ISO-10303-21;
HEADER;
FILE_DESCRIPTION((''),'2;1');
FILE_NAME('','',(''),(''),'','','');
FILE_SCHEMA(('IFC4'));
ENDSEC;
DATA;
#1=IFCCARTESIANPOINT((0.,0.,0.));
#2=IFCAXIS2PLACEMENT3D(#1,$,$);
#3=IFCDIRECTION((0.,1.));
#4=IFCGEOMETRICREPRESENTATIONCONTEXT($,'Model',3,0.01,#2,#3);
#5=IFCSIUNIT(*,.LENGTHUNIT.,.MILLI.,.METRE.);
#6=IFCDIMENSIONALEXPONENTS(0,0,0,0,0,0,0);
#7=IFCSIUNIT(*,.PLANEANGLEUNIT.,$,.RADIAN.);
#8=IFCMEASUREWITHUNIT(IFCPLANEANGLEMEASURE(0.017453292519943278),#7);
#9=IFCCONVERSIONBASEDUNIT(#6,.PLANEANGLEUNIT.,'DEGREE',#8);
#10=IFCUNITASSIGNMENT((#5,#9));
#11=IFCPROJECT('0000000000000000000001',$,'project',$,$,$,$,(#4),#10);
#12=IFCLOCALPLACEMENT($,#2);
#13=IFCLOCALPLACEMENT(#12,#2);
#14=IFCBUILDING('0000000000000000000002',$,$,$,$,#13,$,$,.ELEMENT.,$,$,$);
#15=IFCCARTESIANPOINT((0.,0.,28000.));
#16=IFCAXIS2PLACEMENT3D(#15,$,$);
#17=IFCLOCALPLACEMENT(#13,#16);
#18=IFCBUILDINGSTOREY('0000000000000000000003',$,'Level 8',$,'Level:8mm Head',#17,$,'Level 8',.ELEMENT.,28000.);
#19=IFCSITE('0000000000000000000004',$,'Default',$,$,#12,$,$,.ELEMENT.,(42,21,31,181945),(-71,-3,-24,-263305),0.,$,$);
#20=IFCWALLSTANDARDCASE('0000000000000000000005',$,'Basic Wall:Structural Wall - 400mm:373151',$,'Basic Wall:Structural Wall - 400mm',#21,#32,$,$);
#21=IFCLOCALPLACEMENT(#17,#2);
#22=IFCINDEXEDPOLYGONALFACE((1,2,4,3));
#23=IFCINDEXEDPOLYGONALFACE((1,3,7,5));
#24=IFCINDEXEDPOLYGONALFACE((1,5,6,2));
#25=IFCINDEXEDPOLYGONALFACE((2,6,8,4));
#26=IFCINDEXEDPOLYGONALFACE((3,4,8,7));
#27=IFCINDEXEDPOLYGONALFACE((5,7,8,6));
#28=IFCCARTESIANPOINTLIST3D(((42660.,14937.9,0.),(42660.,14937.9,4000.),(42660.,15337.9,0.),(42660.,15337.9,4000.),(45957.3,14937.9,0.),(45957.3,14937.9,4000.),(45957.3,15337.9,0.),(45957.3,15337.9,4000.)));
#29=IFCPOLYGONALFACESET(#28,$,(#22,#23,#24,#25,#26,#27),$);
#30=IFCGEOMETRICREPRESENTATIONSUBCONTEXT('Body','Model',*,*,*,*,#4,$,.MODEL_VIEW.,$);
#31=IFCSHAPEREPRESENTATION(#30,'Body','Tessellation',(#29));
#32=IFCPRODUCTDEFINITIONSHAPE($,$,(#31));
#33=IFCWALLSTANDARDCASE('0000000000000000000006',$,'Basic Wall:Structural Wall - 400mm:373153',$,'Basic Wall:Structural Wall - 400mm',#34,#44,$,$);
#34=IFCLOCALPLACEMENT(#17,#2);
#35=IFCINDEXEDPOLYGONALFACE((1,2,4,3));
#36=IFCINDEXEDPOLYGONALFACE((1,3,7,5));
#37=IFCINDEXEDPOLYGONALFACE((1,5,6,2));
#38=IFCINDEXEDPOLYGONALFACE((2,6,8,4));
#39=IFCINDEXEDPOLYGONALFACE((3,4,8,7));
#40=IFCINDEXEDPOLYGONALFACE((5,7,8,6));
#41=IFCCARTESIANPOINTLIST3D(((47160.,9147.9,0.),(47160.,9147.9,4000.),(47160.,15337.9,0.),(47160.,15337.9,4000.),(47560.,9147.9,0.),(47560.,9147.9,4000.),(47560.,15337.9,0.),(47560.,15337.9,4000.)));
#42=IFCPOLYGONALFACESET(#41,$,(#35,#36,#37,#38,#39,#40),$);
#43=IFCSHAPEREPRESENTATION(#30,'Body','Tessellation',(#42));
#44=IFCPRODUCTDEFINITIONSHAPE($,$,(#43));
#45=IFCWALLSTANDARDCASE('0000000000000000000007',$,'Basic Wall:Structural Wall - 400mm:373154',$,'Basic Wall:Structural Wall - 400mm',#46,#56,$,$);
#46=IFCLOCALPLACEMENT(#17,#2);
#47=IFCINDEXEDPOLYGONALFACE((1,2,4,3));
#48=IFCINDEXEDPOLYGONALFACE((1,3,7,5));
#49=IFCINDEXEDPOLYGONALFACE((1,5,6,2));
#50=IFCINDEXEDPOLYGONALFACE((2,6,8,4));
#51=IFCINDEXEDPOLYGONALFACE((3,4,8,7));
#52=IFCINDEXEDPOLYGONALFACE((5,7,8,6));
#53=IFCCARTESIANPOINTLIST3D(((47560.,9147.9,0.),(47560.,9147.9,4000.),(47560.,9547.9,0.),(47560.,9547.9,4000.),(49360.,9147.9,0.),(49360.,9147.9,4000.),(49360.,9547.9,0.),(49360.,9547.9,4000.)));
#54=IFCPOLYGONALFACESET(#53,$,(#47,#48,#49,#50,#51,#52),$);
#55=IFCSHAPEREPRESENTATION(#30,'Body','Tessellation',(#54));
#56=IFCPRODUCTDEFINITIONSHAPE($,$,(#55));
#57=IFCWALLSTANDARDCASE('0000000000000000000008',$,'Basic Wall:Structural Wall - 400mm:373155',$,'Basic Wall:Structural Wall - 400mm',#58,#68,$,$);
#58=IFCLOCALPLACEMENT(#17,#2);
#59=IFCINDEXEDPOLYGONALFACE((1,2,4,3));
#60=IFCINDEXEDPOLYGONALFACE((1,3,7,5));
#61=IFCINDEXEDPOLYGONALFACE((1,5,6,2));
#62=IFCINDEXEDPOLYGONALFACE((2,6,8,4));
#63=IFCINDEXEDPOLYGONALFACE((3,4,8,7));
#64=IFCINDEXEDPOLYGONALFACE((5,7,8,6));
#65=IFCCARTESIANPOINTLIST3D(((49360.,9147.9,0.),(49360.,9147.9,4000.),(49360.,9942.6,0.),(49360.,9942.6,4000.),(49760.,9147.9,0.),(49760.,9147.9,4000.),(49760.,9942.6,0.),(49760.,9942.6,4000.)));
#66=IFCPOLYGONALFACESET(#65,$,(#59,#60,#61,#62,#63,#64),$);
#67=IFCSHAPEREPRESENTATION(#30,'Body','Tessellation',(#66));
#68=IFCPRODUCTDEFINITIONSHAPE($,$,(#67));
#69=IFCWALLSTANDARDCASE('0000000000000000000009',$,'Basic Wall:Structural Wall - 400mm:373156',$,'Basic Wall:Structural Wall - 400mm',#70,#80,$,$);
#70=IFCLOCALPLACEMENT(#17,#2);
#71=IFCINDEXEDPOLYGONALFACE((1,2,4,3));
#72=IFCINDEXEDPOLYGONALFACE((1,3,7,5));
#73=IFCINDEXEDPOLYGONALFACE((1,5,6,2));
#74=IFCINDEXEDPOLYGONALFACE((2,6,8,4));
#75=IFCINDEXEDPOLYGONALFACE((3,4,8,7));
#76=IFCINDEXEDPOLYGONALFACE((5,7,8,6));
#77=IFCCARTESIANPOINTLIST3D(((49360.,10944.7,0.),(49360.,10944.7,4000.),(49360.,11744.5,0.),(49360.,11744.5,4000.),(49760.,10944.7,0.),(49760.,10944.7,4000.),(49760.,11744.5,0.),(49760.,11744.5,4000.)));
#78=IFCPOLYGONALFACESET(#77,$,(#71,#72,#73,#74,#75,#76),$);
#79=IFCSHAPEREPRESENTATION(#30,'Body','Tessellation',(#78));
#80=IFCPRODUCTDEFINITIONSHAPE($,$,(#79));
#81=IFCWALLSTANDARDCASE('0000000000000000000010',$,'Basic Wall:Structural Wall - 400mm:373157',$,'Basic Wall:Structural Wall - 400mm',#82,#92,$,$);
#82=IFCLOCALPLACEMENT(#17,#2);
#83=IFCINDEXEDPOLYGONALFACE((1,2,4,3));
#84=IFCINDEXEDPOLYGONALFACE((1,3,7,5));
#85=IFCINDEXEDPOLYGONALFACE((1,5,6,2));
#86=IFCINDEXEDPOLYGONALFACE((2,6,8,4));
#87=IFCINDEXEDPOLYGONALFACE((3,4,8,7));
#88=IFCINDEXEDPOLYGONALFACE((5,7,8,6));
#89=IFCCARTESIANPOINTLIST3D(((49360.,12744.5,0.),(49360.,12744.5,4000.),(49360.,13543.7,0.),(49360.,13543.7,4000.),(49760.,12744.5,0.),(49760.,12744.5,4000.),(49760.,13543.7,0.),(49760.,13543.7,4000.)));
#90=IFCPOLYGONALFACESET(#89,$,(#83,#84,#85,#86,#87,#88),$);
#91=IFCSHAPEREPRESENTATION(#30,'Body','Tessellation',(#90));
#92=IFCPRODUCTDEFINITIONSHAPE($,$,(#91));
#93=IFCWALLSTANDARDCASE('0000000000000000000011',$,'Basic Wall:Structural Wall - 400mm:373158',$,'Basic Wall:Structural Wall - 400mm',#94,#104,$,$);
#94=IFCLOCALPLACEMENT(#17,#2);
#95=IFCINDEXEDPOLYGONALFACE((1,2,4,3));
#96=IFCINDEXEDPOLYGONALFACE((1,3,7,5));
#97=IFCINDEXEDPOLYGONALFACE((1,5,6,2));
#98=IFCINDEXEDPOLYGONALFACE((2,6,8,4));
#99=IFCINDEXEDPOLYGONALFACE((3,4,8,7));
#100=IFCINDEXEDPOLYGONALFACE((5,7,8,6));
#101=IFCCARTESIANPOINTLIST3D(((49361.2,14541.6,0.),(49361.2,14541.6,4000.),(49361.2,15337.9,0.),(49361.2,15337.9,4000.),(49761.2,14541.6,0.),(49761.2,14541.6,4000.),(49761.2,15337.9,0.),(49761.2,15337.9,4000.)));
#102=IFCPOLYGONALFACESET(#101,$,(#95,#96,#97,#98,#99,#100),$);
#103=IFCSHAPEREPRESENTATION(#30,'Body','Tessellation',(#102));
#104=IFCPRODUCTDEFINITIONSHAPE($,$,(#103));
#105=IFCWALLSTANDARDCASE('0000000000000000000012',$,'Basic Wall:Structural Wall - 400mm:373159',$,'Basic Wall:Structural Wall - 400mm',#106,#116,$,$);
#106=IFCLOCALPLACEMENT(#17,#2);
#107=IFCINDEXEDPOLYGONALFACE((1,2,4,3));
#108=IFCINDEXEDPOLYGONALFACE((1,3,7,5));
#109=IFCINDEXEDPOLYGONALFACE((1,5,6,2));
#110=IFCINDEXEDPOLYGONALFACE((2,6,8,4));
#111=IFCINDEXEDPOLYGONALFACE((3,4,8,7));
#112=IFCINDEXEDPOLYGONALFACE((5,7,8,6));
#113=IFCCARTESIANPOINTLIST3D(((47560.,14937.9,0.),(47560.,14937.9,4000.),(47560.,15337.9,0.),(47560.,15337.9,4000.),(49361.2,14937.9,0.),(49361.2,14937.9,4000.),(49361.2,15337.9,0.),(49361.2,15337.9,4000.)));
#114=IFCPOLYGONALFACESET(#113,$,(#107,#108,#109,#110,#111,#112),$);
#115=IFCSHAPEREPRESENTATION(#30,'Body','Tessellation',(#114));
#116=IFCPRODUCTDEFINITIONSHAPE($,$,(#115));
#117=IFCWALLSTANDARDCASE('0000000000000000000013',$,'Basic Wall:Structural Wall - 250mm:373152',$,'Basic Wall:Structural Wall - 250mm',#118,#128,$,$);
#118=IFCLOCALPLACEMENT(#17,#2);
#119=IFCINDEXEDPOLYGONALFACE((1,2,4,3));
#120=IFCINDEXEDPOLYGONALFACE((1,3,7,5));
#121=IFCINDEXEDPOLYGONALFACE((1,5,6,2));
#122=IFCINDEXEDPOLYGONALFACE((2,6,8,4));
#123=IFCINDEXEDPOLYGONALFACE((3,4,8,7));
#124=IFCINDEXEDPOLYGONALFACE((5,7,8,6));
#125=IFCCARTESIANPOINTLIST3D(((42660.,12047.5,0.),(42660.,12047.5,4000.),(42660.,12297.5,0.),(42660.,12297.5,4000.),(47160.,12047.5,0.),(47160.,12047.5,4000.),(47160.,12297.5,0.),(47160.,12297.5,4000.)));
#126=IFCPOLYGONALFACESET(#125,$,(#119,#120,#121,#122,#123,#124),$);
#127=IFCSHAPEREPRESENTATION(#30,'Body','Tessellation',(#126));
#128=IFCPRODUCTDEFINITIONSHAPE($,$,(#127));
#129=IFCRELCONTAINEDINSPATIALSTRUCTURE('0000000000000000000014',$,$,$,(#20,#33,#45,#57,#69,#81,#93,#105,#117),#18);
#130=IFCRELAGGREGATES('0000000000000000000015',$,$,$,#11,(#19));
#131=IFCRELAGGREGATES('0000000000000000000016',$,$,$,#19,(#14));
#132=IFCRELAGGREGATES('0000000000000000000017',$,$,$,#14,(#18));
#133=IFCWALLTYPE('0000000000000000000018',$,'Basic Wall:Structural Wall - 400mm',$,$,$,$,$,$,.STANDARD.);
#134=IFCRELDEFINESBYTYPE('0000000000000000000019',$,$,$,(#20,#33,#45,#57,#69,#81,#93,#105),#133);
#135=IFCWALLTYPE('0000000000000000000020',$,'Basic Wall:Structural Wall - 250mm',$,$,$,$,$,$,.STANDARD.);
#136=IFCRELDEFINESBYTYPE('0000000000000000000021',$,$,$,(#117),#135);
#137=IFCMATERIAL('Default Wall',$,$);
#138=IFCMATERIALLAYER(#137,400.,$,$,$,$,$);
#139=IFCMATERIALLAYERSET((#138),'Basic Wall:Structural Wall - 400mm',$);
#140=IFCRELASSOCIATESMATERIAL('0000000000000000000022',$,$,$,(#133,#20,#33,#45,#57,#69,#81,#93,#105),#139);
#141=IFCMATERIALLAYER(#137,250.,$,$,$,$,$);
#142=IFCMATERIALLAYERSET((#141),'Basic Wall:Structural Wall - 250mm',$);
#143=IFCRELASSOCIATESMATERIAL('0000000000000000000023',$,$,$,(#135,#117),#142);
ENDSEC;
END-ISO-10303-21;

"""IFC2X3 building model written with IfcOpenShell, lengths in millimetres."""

from ifc_helpers import new_model, entity, si_unit, converted_unit, direction, frame, frame_2d, origin, place, context, subcontext, project, spatial, rectangle, extrude, material, layer, layer_set, layer_usage, type_object, element, save


model = new_model("IFC2X3")

# Units and contexts
model_context = context("Model", 3, precision=0.01, world=origin(), true_north=direction((0.0, 1.0)))
body_context = subcontext(model_context, "Body", "Model", "MODEL_VIEW")
ifc_project = project(units=[si_unit("LENGTHUNIT", "METRE", prefix="MILLI"), converted_unit("PLANEANGLEUNIT", "DEGREE", entity("IfcPlaneAngleMeasure", 0.017453292519943278), si_unit("PLANEANGLEUNIT", "RADIAN"), dimensions=[0, 0, 0, 0, 0, 0, 0])], contexts=[model_context])

# Site, building, storey
site_placement = place(None, origin())
site = spatial("IfcSite", under=ifc_project, at=site_placement, Name="Default", CompositionType="ELEMENT", RefLatitude=(42, 21, 31, 181945), RefLongitude=(-71, -3, -24, -263305), RefElevation=0.0)
building_placement = place(site_placement, origin())
building = spatial("IfcBuilding", under=site, at=building_placement, CompositionType="ELEMENT")
storey_placement = place(building_placement, frame((0.0, 0.0, 28000.0)))
storey = spatial("IfcBuildingStorey", under=building, at=storey_placement, Name="Level 8", ObjectType="Level:8mm Head", LongName="Level 8", CompositionType="ELEMENT", Elevation=28000.0)

# Walls
ifc_material = material(Name="Default Wall")
ifc_layer_1 = layer(ifc_material, 400.0)
ifc_layer_set_1 = layer_set([ifc_layer_1], Name="Basic Wall:Structural Wall - 400mm")
wall_type_1 = type_object("IfcWallType", Name="Basic Wall:Structural Wall - 400mm", PredefinedType="STANDARD", material=ifc_layer_set_1)
ifc_layer_usage_1 = layer_usage(ifc_layer_set_1, "AXIS2", "POSITIVE", -200.0)
wall_1_placement = place(storey_placement, frame((45957.3, 15137.9, 0.0), z_axis=(0.0, 0.0, 1.0), x_axis=(-1.0, 0.0, 0.0)))
element("IfcWallStandardCase", 1, at=wall_1_placement, inside=storey, type_object=wall_type_1, material=ifc_layer_usage_1, Name="Basic Wall:Structural Wall - 400mm:373151", ObjectType="Basic Wall:Structural Wall - 400mm", context=body_context, shape_type="SweptSolid", body=[
    extrude(rectangle(XDim=3297.3, YDim=400.0, at=frame_2d((1648.6, 0.0), x_axis=(-1.0, 0.0))), origin(), (0.0, 0.0, 1.0), 4000.0),
])
ifc_layer_usage_2 = layer_usage(ifc_layer_set_1, "AXIS2", "POSITIVE", -200.0)
wall_2_placement = place(storey_placement, frame((47360.0, 15337.9, 0.0), z_axis=(0.0, 0.0, 1.0), x_axis=(0.0, -1.0, 0.0)))
element("IfcWallStandardCase", 2, at=wall_2_placement, inside=storey, type_object=wall_type_1, material=ifc_layer_usage_2, Name="Basic Wall:Structural Wall - 400mm:373153", ObjectType="Basic Wall:Structural Wall - 400mm", context=body_context, shape_type="SweptSolid", body=[
    extrude(rectangle(XDim=6190.0, YDim=400.0, at=frame_2d((3095.0, 0.0), x_axis=(-1.0, 0.0))), origin(), (0.0, 0.0, 1.0), 4000.0),
])
ifc_layer_usage_3 = layer_usage(ifc_layer_set_1, "AXIS2", "POSITIVE", -200.0)
wall_3_placement = place(storey_placement, frame((47560.0, 9347.9, 0.0)))
element("IfcWallStandardCase", 3, at=wall_3_placement, inside=storey, type_object=wall_type_1, material=ifc_layer_usage_3, Name="Basic Wall:Structural Wall - 400mm:373154", ObjectType="Basic Wall:Structural Wall - 400mm", context=body_context, shape_type="SweptSolid", body=[
    extrude(rectangle(XDim=1800.0, YDim=400.0, at=frame_2d((900.0, 0.0), x_axis=(-1.0, 0.0))), origin(), (0.0, 0.0, 1.0), 4000.0),
])
ifc_layer_usage_4 = layer_usage(ifc_layer_set_1, "AXIS2", "NEGATIVE", 200.0)
wall_4_placement = place(storey_placement, frame((49560.0, 9147.9, 0.0), z_axis=(0.0, 0.0, 1.0), x_axis=(0.0, 1.0, 0.0)))
element("IfcWallStandardCase", 4, at=wall_4_placement, inside=storey, type_object=wall_type_1, material=ifc_layer_usage_4, Name="Basic Wall:Structural Wall - 400mm:373155", ObjectType="Basic Wall:Structural Wall - 400mm", context=body_context, shape_type="SweptSolid", body=[
    extrude(rectangle(XDim=794.7, YDim=400.0, at=frame_2d((397.3, 0.0), x_axis=(-1.0, 0.0))), origin(), (0.0, 0.0, 1.0), 4000.0),
])
ifc_layer_usage_5 = layer_usage(ifc_layer_set_1, "AXIS2", "POSITIVE", -200.0)
wall_5_placement = place(storey_placement, frame((49560.0, 10944.7, 0.0), z_axis=(0.0, 0.0, 1.0), x_axis=(0.0, 1.0, 0.0)))
element("IfcWallStandardCase", 5, at=wall_5_placement, inside=storey, type_object=wall_type_1, material=ifc_layer_usage_5, Name="Basic Wall:Structural Wall - 400mm:373156", ObjectType="Basic Wall:Structural Wall - 400mm", context=body_context, shape_type="SweptSolid", body=[
    extrude(rectangle(XDim=799.8, YDim=400.0, at=frame_2d((399.9, 0.0), x_axis=(-1.0, 0.0))), origin(), (0.0, 0.0, 1.0), 4000.0),
])
ifc_layer_usage_6 = layer_usage(ifc_layer_set_1, "AXIS2", "POSITIVE", -200.0)
wall_6_placement = place(storey_placement, frame((49560.0, 12744.5, 0.0), z_axis=(0.0, 0.0, 1.0), x_axis=(0.0, 1.0, 0.0)))
element("IfcWallStandardCase", 6, at=wall_6_placement, inside=storey, type_object=wall_type_1, material=ifc_layer_usage_6, Name="Basic Wall:Structural Wall - 400mm:373157", ObjectType="Basic Wall:Structural Wall - 400mm", context=body_context, shape_type="SweptSolid", body=[
    extrude(rectangle(XDim=799.2, YDim=400.0, at=frame_2d((399.6, 0.0), x_axis=(-1.0, 0.0))), origin(), (0.0, 0.0, 1.0), 4000.0),
])
ifc_layer_usage_7 = layer_usage(ifc_layer_set_1, "AXIS2", "POSITIVE", -200.0)
wall_7_placement = place(storey_placement, frame((49561.2, 14541.6, 0.0), z_axis=(0.0, 0.0, 1.0), x_axis=(0.0, 1.0, 0.0)))
element("IfcWallStandardCase", 7, at=wall_7_placement, inside=storey, type_object=wall_type_1, material=ifc_layer_usage_7, Name="Basic Wall:Structural Wall - 400mm:373158", ObjectType="Basic Wall:Structural Wall - 400mm", context=body_context, shape_type="SweptSolid", body=[
    extrude(rectangle(XDim=796.3, YDim=400.0, at=frame_2d((398.2, 0.0), x_axis=(-1.0, 0.0))), origin(), (0.0, 0.0, 1.0), 4000.0),
])
ifc_layer_usage_8 = layer_usage(ifc_layer_set_1, "AXIS2", "POSITIVE", -200.0)
wall_8_placement = place(storey_placement, frame((49361.2, 15137.9, 0.0), z_axis=(0.0, 0.0, 1.0), x_axis=(-1.0, 0.0, 0.0)))
element("IfcWallStandardCase", 8, at=wall_8_placement, inside=storey, type_object=wall_type_1, material=ifc_layer_usage_8, Name="Basic Wall:Structural Wall - 400mm:373159", ObjectType="Basic Wall:Structural Wall - 400mm", context=body_context, shape_type="SweptSolid", body=[
    extrude(rectangle(XDim=1801.2, YDim=400.0, at=frame_2d((900.6, 0.0), x_axis=(-1.0, 0.0))), origin(), (0.0, 0.0, 1.0), 4000.0),
])
ifc_layer_2 = layer(ifc_material, 250.0)
ifc_layer_set_2 = layer_set([ifc_layer_2], Name="Basic Wall:Structural Wall - 250mm")
ifc_layer_usage_9 = layer_usage(ifc_layer_set_2, "AXIS2", "NEGATIVE", 125.0)
wall_type_2 = type_object("IfcWallType", Name="Basic Wall:Structural Wall - 250mm", PredefinedType="STANDARD", material=ifc_layer_set_2)
wall_9_placement = place(storey_placement, frame((42660.0, 12172.5, 0.0)))
element("IfcWallStandardCase", 9, at=wall_9_placement, inside=storey, type_object=wall_type_2, material=ifc_layer_usage_9, Name="Basic Wall:Structural Wall - 250mm:373152", ObjectType="Basic Wall:Structural Wall - 250mm", context=body_context, shape_type="SweptSolid", body=[
    extrude(rectangle(XDim=4500.0, YDim=250.0, at=frame_2d((2250.0, 0.0), x_axis=(-1.0, 0.0))), origin(), (0.0, 0.0, 1.0), 4000.0),
])

save(model, "model.ifc")
